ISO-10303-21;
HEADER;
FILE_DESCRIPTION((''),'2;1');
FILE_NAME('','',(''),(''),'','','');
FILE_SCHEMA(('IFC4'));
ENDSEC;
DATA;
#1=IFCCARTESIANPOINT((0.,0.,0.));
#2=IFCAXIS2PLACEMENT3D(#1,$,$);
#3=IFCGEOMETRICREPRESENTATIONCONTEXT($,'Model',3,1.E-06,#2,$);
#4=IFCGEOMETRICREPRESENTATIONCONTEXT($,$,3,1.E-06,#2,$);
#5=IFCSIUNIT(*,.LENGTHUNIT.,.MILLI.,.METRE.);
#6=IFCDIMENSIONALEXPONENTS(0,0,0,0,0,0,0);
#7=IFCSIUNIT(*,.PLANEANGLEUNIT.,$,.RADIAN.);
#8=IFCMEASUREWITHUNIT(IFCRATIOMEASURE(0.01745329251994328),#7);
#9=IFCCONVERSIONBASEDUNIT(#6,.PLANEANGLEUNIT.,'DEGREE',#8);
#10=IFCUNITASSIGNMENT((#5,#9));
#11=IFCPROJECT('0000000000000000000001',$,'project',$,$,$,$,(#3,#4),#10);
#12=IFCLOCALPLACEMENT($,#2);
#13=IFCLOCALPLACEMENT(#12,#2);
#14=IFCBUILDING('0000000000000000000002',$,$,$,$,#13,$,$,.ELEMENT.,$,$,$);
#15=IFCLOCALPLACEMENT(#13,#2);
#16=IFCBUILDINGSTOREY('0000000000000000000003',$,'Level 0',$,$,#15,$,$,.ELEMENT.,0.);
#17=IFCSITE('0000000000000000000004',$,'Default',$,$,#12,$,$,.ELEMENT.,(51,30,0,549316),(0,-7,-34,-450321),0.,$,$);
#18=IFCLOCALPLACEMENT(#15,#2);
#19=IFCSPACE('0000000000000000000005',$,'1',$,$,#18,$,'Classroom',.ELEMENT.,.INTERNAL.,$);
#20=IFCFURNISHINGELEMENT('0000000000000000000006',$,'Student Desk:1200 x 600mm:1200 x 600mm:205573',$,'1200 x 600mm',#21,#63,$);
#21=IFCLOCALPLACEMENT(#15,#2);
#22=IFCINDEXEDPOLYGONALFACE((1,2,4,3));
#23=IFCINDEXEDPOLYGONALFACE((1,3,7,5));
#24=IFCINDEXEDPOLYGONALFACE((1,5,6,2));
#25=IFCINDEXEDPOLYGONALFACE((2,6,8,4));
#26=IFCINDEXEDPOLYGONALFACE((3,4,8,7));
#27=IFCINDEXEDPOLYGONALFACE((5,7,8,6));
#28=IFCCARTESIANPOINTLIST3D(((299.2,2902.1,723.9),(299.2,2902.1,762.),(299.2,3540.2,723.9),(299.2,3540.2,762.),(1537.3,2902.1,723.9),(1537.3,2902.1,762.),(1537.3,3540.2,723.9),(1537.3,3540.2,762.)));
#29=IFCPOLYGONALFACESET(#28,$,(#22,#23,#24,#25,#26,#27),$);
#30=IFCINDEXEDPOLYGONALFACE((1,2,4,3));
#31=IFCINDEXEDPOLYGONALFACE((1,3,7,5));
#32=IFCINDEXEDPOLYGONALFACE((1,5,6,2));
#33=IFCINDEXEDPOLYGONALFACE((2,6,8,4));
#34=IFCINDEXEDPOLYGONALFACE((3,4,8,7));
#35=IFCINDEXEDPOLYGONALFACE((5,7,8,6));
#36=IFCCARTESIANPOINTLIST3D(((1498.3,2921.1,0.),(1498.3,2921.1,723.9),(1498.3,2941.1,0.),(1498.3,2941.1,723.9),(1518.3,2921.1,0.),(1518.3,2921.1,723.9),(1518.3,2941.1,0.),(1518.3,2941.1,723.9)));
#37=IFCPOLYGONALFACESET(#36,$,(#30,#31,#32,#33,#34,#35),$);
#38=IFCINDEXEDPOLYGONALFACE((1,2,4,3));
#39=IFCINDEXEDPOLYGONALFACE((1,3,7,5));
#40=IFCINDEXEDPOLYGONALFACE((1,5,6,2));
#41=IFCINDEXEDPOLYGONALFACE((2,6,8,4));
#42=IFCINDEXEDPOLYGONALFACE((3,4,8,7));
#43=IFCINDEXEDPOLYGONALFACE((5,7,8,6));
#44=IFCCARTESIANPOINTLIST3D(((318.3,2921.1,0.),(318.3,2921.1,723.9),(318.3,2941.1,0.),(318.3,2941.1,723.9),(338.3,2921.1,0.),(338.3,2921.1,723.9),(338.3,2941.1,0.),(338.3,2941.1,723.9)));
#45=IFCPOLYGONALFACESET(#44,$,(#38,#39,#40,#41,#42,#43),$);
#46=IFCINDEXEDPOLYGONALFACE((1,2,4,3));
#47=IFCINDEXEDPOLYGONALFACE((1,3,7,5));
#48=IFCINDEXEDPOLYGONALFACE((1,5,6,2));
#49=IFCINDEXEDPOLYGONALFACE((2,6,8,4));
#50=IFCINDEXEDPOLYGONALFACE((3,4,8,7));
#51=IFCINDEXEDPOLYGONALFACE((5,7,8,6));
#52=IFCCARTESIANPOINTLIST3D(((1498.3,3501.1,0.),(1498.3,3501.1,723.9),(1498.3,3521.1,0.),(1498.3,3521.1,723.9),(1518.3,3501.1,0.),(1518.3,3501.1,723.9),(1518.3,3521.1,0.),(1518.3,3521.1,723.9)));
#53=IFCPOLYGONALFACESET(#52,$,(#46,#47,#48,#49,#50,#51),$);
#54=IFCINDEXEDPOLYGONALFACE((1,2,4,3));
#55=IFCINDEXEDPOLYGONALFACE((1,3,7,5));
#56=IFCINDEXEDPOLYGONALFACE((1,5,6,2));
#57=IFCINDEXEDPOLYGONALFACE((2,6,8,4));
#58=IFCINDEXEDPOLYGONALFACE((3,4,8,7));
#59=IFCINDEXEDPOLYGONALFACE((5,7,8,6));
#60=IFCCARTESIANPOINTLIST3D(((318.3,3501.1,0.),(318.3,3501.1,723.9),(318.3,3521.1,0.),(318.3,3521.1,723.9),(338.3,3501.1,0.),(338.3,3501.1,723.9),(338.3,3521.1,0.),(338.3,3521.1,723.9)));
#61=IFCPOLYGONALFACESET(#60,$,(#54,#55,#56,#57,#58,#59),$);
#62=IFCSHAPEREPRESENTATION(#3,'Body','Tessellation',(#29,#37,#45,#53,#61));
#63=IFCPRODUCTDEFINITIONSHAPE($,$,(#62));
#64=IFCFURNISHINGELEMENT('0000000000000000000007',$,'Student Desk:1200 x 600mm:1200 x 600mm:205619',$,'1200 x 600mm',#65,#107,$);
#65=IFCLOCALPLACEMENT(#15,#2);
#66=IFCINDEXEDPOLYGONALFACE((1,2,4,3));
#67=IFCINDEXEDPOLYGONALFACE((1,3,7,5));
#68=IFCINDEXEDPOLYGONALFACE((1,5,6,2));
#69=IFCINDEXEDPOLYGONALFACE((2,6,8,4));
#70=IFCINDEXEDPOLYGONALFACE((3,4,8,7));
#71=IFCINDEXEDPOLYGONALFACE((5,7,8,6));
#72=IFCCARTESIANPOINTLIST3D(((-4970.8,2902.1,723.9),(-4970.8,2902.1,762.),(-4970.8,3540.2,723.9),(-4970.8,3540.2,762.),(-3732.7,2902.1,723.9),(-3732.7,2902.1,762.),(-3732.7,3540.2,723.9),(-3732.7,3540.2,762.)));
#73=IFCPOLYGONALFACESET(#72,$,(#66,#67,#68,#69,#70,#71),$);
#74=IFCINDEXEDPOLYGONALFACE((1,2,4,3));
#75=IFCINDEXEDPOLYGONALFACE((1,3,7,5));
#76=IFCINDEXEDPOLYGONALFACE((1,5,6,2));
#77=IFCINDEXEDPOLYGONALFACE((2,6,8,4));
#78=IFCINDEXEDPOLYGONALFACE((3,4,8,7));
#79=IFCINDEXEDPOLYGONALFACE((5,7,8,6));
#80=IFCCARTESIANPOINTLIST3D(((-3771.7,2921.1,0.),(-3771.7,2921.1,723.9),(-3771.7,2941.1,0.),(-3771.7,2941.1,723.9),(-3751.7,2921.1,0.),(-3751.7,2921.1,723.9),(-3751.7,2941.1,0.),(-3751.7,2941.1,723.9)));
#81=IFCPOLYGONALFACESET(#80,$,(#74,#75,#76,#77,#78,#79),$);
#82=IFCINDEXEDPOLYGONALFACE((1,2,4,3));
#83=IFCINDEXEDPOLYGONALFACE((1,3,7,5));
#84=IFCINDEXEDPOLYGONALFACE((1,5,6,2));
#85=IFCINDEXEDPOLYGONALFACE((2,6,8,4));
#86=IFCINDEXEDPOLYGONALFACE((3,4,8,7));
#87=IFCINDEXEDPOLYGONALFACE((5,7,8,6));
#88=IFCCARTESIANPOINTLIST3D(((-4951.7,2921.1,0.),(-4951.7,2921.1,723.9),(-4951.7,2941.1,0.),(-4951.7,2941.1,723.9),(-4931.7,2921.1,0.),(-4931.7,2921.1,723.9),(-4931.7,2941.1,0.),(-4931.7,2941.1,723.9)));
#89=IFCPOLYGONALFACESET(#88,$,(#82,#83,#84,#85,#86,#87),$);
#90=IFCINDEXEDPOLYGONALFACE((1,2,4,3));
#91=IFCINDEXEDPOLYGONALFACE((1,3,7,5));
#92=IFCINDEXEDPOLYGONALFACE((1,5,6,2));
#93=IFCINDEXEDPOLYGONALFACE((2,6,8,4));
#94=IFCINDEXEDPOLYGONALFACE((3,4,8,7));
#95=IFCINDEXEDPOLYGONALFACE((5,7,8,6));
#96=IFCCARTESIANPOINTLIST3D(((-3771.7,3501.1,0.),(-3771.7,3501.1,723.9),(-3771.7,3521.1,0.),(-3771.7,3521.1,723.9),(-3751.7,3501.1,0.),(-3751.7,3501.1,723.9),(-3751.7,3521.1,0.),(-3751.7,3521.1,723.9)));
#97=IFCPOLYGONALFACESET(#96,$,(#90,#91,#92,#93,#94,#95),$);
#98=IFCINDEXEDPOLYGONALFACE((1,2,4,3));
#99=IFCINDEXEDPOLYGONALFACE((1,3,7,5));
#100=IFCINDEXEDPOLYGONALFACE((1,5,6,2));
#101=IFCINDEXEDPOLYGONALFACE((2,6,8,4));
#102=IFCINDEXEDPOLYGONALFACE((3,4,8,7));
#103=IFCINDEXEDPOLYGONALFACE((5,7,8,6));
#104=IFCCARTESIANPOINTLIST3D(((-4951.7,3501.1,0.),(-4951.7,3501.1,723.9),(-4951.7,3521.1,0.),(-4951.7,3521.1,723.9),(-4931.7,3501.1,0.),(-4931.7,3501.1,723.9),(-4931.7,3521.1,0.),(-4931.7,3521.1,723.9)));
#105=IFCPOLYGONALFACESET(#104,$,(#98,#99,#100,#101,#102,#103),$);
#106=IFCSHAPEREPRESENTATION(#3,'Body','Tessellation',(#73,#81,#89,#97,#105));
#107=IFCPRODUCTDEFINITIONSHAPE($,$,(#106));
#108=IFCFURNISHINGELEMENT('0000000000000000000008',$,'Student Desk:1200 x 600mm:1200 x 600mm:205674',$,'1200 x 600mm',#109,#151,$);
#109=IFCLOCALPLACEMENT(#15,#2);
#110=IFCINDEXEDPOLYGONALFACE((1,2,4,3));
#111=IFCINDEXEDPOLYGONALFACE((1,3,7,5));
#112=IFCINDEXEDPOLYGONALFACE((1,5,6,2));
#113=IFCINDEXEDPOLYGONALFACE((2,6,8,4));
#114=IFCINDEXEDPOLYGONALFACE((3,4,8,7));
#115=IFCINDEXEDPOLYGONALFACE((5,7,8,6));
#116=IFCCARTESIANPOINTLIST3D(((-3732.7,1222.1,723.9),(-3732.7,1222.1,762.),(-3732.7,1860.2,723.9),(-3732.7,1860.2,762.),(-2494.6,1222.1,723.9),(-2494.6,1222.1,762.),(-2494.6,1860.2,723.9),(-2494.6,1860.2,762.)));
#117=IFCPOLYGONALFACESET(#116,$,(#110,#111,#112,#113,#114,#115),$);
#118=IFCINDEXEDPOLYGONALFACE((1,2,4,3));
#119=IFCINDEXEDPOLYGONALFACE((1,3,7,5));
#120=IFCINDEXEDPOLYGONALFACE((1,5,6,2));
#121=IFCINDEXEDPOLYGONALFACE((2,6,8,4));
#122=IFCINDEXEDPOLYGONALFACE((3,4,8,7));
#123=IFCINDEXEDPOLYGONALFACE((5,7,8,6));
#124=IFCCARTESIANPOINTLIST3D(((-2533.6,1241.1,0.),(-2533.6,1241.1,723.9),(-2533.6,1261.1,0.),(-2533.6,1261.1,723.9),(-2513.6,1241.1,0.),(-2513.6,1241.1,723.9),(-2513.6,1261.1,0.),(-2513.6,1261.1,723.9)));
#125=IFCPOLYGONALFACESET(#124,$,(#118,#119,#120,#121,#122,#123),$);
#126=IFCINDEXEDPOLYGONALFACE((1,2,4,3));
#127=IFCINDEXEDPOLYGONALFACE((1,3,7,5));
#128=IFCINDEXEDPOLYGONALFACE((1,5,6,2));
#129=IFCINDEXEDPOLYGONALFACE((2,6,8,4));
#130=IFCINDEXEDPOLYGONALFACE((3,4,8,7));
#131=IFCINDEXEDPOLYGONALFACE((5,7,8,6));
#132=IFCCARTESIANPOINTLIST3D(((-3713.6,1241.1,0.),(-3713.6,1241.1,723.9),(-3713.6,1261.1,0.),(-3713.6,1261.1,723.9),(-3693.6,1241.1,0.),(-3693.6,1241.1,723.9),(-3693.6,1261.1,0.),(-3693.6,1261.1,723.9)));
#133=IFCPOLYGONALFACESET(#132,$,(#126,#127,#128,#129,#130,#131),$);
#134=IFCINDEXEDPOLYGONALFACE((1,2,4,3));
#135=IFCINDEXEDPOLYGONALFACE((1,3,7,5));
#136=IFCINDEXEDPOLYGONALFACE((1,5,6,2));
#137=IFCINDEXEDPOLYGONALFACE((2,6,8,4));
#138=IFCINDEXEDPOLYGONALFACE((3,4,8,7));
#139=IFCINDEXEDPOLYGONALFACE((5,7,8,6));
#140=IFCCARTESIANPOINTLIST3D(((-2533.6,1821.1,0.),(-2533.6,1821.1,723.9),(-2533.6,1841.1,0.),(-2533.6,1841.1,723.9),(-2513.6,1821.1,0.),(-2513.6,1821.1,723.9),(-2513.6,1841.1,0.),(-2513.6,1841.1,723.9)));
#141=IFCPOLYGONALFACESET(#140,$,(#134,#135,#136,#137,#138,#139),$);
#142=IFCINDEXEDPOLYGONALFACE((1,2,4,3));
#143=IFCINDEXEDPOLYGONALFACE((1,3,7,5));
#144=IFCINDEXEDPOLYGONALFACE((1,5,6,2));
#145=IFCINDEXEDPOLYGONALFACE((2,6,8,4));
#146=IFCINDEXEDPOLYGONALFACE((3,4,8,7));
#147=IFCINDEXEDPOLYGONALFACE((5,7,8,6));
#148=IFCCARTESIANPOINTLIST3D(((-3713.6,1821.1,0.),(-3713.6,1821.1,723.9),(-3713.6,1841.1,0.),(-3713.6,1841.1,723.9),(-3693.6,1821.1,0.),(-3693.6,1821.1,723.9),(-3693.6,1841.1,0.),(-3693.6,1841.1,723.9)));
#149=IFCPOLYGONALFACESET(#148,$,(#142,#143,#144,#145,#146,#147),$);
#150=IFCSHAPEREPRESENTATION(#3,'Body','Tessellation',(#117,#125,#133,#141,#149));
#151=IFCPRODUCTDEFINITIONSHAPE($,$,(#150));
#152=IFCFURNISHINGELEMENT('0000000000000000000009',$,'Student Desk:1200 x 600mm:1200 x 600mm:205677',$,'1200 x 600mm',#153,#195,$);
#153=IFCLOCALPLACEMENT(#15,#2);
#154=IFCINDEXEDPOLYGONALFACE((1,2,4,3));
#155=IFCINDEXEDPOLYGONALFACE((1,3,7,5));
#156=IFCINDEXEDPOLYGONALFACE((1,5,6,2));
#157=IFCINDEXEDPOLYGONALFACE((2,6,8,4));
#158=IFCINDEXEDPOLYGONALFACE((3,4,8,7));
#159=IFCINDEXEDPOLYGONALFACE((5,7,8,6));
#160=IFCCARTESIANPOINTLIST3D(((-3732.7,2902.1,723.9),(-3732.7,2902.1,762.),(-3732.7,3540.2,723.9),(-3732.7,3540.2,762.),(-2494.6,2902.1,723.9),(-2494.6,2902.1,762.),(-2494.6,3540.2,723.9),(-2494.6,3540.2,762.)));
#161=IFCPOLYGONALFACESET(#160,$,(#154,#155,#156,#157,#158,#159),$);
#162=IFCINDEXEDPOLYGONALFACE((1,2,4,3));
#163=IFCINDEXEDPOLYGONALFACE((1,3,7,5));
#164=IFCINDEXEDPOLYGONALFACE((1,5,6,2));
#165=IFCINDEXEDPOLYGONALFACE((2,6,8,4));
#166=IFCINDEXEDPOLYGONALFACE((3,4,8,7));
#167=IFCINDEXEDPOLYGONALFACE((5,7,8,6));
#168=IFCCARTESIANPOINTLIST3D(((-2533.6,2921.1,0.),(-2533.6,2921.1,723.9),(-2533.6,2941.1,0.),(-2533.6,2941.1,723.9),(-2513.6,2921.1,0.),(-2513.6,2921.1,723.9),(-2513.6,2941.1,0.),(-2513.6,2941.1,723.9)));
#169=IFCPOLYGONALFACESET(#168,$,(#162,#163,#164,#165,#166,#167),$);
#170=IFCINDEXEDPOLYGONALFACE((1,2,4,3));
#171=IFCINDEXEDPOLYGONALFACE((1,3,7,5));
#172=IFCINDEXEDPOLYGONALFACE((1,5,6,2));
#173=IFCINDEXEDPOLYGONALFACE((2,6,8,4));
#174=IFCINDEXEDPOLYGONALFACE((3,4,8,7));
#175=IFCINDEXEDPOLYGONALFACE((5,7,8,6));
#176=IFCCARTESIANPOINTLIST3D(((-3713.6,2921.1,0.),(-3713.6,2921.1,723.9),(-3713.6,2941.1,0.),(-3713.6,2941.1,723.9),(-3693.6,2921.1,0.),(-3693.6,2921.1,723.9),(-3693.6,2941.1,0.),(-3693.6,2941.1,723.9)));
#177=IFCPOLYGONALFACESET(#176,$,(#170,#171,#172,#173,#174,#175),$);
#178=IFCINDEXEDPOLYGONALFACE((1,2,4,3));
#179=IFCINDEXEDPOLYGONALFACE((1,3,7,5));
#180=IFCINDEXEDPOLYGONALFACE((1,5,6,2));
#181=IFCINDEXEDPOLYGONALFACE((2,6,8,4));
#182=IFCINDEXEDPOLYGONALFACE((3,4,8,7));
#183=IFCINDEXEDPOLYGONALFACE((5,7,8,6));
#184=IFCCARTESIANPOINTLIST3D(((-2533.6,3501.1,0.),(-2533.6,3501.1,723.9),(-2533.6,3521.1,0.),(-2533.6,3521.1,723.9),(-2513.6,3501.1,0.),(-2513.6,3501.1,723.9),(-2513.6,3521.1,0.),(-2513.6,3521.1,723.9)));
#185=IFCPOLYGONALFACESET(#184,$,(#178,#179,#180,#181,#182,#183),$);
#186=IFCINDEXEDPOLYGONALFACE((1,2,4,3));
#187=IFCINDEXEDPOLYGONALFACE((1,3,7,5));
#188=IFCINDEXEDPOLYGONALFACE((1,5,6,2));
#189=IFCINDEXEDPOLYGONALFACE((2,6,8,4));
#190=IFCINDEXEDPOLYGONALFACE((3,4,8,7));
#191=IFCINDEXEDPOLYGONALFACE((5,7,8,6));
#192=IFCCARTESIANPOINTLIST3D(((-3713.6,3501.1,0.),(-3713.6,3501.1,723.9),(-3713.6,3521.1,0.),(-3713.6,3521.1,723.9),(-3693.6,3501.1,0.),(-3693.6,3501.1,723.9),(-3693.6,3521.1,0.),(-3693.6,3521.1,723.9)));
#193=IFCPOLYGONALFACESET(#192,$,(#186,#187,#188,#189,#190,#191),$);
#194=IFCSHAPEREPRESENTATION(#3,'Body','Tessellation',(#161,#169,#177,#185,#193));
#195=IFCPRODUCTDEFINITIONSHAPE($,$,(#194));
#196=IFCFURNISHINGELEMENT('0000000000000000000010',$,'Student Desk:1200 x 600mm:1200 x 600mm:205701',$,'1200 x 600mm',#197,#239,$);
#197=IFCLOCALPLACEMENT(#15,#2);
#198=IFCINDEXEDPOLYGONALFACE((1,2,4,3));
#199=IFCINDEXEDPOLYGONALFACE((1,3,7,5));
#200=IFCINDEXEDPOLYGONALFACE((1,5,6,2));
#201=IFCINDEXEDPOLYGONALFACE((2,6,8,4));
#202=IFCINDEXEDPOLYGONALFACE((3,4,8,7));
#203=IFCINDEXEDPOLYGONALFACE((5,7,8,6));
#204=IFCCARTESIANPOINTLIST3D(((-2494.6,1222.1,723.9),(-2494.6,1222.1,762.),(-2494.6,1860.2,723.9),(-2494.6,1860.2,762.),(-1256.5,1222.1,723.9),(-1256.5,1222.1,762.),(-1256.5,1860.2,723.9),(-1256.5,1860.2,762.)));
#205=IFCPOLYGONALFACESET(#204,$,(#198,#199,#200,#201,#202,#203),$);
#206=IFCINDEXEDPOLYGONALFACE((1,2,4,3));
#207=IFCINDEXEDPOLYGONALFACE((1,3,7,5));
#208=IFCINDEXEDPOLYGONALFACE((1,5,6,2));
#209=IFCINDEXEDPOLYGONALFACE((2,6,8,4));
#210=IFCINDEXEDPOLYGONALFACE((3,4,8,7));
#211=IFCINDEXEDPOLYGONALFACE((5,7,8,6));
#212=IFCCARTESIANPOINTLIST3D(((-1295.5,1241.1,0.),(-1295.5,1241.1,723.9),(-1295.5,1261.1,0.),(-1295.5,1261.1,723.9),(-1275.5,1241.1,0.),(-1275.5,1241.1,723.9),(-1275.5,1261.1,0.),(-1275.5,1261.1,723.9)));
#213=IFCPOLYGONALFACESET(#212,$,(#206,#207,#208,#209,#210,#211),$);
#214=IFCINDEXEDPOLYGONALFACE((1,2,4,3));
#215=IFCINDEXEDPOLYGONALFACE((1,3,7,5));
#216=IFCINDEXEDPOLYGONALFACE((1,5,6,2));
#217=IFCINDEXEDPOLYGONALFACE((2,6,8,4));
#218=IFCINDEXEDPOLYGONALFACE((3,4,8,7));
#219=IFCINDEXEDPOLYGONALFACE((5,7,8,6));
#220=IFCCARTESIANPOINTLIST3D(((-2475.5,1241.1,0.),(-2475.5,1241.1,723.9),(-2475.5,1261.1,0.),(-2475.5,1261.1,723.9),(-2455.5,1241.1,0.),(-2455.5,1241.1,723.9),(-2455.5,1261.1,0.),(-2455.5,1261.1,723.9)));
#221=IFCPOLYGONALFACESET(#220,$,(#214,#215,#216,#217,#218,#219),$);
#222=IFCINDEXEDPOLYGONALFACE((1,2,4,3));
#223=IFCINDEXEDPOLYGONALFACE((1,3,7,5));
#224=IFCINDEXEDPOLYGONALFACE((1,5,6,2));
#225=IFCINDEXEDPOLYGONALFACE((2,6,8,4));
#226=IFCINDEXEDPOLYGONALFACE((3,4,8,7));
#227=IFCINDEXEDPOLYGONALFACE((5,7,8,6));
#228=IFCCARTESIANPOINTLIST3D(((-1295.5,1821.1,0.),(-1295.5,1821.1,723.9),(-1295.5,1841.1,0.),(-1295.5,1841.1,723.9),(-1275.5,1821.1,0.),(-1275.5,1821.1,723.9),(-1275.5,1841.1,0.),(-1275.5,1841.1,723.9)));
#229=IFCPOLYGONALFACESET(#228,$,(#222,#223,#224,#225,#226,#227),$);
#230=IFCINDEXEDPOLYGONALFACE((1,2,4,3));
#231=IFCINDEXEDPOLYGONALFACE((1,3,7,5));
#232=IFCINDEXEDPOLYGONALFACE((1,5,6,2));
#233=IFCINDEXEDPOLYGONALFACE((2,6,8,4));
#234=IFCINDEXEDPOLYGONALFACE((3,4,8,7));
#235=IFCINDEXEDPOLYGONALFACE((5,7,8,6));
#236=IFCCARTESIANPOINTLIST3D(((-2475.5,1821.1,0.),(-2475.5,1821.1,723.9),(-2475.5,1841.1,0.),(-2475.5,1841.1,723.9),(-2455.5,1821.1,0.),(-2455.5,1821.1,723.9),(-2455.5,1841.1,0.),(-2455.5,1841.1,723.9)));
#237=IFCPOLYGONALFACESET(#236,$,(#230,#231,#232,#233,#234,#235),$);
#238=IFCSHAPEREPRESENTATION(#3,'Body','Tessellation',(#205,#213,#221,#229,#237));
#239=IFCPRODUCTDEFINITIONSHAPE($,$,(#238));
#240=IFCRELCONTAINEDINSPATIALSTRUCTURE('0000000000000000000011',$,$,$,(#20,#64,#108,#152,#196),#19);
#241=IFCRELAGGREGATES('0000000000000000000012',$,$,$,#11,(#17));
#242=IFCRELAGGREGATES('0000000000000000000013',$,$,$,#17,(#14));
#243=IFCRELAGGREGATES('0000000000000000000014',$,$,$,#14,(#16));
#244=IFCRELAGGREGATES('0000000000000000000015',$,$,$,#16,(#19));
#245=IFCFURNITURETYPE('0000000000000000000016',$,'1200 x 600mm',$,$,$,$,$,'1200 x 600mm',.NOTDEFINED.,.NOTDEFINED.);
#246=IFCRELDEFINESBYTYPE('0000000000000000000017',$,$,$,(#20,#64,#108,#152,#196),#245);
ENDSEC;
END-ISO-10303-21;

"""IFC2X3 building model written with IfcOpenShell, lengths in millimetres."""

from ifc_helpers import new_model, entity, si_unit, converted_unit, frame, origin, origin_2d_with_axis, place, context, project, spatial, rectangle, extrude, source, transform, mapped, type_object, type_shapes, element, save


model = new_model("IFC2X3")

# Units and contexts
model_context = context("Model", 3, precision=1e-06, world=origin())
context_of_model = context(None, 3, precision=1e-06, world=origin())
ifc_project = project(units=[si_unit("LENGTHUNIT", "METRE", prefix="MILLI"), converted_unit("PLANEANGLEUNIT", "DEGREE", entity("IfcRatioMeasure", 0.01745329251994328), si_unit("PLANEANGLEUNIT", "RADIAN"), dimensions=[0, 0, 0, 0, 0, 0, 0])], contexts=[model_context, context_of_model])

# Site, building, storey
site_placement = place(None, origin())
site = spatial("IfcSite", under=ifc_project, at=site_placement, Name="Default", CompositionType="ELEMENT", RefLatitude=(51, 30, 0, 549316), RefLongitude=(0, -7, -34, -450321), RefElevation=0.0)
building_placement = place(site_placement, origin())
building = spatial("IfcBuilding", under=site, at=building_placement, CompositionType="ELEMENT")
storey_placement = place(building_placement, origin())
storey = spatial("IfcBuildingStorey", under=building, at=storey_placement, Name="Level 0", CompositionType="ELEMENT", Elevation=0.0)

# Shared definitions
space_placement = place(storey_placement, origin())
space = spatial("IfcSpace", under=storey, at=space_placement, Name="1", LongName="Classroom", CompositionType="ELEMENT", InteriorOrExteriorSpace="INTERNAL")

# Furnishing elements
furniture_type = type_object("IfcFurnitureType", Name="1200 x 600mm", ElementType="1200 x 600mm", AssemblyPlace="NOTDEFINED")
shared_shape_1 = source(origin(), model_context, "Body", "SweptSolid", [
    extrude(rectangle(XDim=1238.1, YDim=638.1, at=origin_2d_with_axis()), frame((600.0, 300.0, 723.9), z_axis=(0.0, 0.0, 1.0), x_axis=(-1.0, 0.0, 0.0)), (0.0, 0.0, 1.0), 38.1),
    extrude(rectangle(XDim=20.0, YDim=20.0, at=origin_2d_with_axis()), frame((1190.0, 10.0, 0.0)), (0.0, 0.0, 1.0), 723.9),
    extrude(rectangle(XDim=20.0, YDim=20.0, at=origin_2d_with_axis()), frame((10.0, 10.0, 0.0), z_axis=(0.0, 0.0, 1.0), x_axis=(0.0, 1.0, 0.0)), (0.0, 0.0, 1.0), 723.9),
    extrude(rectangle(XDim=20.0, YDim=20.0, at=origin_2d_with_axis()), frame((1190.0, 590.0, 0.0), z_axis=(0.0, 0.0, 1.0), x_axis=(0.0, -1.0, 0.0)), (0.0, 0.0, 1.0), 723.9),
    extrude(rectangle(XDim=20.0, YDim=20.0, at=origin_2d_with_axis()), frame((10.0, 590.0, 0.0), z_axis=(0.0, 0.0, 1.0), x_axis=(-1.0, 0.0, 0.0)), (0.0, 0.0, 1.0), 723.9),
])
type_shapes(furniture_type, [shared_shape_1])
for number, where, name in (
    (1, (318.3, 2921.1, 0.0), "Student Desk:1200 x 600mm:1200 x 600mm:205573"),
    (2, (-4951.7, 2921.1, 0.0), "Student Desk:1200 x 600mm:1200 x 600mm:205619"),
    (3, (-3713.6, 1241.1, 0.0), "Student Desk:1200 x 600mm:1200 x 600mm:205674"),
    (4, (-3713.6, 2921.1, 0.0), "Student Desk:1200 x 600mm:1200 x 600mm:205677"),
    (5, (-2475.5, 1241.1, 0.0), "Student Desk:1200 x 600mm:1200 x 600mm:205701"),
):
    element("IfcFurnishingElement", number, at=place(space_placement, frame(where)), inside=space, type_object=furniture_type, Name=name, ObjectType="1200 x 600mm", context=model_context, shape_type="MappedRepresentation", body=[
        mapped(shared_shape_1, transform((0.0, 0.0, 0.0), scale=1.0)),
    ])

save(model, "model.ifc")
